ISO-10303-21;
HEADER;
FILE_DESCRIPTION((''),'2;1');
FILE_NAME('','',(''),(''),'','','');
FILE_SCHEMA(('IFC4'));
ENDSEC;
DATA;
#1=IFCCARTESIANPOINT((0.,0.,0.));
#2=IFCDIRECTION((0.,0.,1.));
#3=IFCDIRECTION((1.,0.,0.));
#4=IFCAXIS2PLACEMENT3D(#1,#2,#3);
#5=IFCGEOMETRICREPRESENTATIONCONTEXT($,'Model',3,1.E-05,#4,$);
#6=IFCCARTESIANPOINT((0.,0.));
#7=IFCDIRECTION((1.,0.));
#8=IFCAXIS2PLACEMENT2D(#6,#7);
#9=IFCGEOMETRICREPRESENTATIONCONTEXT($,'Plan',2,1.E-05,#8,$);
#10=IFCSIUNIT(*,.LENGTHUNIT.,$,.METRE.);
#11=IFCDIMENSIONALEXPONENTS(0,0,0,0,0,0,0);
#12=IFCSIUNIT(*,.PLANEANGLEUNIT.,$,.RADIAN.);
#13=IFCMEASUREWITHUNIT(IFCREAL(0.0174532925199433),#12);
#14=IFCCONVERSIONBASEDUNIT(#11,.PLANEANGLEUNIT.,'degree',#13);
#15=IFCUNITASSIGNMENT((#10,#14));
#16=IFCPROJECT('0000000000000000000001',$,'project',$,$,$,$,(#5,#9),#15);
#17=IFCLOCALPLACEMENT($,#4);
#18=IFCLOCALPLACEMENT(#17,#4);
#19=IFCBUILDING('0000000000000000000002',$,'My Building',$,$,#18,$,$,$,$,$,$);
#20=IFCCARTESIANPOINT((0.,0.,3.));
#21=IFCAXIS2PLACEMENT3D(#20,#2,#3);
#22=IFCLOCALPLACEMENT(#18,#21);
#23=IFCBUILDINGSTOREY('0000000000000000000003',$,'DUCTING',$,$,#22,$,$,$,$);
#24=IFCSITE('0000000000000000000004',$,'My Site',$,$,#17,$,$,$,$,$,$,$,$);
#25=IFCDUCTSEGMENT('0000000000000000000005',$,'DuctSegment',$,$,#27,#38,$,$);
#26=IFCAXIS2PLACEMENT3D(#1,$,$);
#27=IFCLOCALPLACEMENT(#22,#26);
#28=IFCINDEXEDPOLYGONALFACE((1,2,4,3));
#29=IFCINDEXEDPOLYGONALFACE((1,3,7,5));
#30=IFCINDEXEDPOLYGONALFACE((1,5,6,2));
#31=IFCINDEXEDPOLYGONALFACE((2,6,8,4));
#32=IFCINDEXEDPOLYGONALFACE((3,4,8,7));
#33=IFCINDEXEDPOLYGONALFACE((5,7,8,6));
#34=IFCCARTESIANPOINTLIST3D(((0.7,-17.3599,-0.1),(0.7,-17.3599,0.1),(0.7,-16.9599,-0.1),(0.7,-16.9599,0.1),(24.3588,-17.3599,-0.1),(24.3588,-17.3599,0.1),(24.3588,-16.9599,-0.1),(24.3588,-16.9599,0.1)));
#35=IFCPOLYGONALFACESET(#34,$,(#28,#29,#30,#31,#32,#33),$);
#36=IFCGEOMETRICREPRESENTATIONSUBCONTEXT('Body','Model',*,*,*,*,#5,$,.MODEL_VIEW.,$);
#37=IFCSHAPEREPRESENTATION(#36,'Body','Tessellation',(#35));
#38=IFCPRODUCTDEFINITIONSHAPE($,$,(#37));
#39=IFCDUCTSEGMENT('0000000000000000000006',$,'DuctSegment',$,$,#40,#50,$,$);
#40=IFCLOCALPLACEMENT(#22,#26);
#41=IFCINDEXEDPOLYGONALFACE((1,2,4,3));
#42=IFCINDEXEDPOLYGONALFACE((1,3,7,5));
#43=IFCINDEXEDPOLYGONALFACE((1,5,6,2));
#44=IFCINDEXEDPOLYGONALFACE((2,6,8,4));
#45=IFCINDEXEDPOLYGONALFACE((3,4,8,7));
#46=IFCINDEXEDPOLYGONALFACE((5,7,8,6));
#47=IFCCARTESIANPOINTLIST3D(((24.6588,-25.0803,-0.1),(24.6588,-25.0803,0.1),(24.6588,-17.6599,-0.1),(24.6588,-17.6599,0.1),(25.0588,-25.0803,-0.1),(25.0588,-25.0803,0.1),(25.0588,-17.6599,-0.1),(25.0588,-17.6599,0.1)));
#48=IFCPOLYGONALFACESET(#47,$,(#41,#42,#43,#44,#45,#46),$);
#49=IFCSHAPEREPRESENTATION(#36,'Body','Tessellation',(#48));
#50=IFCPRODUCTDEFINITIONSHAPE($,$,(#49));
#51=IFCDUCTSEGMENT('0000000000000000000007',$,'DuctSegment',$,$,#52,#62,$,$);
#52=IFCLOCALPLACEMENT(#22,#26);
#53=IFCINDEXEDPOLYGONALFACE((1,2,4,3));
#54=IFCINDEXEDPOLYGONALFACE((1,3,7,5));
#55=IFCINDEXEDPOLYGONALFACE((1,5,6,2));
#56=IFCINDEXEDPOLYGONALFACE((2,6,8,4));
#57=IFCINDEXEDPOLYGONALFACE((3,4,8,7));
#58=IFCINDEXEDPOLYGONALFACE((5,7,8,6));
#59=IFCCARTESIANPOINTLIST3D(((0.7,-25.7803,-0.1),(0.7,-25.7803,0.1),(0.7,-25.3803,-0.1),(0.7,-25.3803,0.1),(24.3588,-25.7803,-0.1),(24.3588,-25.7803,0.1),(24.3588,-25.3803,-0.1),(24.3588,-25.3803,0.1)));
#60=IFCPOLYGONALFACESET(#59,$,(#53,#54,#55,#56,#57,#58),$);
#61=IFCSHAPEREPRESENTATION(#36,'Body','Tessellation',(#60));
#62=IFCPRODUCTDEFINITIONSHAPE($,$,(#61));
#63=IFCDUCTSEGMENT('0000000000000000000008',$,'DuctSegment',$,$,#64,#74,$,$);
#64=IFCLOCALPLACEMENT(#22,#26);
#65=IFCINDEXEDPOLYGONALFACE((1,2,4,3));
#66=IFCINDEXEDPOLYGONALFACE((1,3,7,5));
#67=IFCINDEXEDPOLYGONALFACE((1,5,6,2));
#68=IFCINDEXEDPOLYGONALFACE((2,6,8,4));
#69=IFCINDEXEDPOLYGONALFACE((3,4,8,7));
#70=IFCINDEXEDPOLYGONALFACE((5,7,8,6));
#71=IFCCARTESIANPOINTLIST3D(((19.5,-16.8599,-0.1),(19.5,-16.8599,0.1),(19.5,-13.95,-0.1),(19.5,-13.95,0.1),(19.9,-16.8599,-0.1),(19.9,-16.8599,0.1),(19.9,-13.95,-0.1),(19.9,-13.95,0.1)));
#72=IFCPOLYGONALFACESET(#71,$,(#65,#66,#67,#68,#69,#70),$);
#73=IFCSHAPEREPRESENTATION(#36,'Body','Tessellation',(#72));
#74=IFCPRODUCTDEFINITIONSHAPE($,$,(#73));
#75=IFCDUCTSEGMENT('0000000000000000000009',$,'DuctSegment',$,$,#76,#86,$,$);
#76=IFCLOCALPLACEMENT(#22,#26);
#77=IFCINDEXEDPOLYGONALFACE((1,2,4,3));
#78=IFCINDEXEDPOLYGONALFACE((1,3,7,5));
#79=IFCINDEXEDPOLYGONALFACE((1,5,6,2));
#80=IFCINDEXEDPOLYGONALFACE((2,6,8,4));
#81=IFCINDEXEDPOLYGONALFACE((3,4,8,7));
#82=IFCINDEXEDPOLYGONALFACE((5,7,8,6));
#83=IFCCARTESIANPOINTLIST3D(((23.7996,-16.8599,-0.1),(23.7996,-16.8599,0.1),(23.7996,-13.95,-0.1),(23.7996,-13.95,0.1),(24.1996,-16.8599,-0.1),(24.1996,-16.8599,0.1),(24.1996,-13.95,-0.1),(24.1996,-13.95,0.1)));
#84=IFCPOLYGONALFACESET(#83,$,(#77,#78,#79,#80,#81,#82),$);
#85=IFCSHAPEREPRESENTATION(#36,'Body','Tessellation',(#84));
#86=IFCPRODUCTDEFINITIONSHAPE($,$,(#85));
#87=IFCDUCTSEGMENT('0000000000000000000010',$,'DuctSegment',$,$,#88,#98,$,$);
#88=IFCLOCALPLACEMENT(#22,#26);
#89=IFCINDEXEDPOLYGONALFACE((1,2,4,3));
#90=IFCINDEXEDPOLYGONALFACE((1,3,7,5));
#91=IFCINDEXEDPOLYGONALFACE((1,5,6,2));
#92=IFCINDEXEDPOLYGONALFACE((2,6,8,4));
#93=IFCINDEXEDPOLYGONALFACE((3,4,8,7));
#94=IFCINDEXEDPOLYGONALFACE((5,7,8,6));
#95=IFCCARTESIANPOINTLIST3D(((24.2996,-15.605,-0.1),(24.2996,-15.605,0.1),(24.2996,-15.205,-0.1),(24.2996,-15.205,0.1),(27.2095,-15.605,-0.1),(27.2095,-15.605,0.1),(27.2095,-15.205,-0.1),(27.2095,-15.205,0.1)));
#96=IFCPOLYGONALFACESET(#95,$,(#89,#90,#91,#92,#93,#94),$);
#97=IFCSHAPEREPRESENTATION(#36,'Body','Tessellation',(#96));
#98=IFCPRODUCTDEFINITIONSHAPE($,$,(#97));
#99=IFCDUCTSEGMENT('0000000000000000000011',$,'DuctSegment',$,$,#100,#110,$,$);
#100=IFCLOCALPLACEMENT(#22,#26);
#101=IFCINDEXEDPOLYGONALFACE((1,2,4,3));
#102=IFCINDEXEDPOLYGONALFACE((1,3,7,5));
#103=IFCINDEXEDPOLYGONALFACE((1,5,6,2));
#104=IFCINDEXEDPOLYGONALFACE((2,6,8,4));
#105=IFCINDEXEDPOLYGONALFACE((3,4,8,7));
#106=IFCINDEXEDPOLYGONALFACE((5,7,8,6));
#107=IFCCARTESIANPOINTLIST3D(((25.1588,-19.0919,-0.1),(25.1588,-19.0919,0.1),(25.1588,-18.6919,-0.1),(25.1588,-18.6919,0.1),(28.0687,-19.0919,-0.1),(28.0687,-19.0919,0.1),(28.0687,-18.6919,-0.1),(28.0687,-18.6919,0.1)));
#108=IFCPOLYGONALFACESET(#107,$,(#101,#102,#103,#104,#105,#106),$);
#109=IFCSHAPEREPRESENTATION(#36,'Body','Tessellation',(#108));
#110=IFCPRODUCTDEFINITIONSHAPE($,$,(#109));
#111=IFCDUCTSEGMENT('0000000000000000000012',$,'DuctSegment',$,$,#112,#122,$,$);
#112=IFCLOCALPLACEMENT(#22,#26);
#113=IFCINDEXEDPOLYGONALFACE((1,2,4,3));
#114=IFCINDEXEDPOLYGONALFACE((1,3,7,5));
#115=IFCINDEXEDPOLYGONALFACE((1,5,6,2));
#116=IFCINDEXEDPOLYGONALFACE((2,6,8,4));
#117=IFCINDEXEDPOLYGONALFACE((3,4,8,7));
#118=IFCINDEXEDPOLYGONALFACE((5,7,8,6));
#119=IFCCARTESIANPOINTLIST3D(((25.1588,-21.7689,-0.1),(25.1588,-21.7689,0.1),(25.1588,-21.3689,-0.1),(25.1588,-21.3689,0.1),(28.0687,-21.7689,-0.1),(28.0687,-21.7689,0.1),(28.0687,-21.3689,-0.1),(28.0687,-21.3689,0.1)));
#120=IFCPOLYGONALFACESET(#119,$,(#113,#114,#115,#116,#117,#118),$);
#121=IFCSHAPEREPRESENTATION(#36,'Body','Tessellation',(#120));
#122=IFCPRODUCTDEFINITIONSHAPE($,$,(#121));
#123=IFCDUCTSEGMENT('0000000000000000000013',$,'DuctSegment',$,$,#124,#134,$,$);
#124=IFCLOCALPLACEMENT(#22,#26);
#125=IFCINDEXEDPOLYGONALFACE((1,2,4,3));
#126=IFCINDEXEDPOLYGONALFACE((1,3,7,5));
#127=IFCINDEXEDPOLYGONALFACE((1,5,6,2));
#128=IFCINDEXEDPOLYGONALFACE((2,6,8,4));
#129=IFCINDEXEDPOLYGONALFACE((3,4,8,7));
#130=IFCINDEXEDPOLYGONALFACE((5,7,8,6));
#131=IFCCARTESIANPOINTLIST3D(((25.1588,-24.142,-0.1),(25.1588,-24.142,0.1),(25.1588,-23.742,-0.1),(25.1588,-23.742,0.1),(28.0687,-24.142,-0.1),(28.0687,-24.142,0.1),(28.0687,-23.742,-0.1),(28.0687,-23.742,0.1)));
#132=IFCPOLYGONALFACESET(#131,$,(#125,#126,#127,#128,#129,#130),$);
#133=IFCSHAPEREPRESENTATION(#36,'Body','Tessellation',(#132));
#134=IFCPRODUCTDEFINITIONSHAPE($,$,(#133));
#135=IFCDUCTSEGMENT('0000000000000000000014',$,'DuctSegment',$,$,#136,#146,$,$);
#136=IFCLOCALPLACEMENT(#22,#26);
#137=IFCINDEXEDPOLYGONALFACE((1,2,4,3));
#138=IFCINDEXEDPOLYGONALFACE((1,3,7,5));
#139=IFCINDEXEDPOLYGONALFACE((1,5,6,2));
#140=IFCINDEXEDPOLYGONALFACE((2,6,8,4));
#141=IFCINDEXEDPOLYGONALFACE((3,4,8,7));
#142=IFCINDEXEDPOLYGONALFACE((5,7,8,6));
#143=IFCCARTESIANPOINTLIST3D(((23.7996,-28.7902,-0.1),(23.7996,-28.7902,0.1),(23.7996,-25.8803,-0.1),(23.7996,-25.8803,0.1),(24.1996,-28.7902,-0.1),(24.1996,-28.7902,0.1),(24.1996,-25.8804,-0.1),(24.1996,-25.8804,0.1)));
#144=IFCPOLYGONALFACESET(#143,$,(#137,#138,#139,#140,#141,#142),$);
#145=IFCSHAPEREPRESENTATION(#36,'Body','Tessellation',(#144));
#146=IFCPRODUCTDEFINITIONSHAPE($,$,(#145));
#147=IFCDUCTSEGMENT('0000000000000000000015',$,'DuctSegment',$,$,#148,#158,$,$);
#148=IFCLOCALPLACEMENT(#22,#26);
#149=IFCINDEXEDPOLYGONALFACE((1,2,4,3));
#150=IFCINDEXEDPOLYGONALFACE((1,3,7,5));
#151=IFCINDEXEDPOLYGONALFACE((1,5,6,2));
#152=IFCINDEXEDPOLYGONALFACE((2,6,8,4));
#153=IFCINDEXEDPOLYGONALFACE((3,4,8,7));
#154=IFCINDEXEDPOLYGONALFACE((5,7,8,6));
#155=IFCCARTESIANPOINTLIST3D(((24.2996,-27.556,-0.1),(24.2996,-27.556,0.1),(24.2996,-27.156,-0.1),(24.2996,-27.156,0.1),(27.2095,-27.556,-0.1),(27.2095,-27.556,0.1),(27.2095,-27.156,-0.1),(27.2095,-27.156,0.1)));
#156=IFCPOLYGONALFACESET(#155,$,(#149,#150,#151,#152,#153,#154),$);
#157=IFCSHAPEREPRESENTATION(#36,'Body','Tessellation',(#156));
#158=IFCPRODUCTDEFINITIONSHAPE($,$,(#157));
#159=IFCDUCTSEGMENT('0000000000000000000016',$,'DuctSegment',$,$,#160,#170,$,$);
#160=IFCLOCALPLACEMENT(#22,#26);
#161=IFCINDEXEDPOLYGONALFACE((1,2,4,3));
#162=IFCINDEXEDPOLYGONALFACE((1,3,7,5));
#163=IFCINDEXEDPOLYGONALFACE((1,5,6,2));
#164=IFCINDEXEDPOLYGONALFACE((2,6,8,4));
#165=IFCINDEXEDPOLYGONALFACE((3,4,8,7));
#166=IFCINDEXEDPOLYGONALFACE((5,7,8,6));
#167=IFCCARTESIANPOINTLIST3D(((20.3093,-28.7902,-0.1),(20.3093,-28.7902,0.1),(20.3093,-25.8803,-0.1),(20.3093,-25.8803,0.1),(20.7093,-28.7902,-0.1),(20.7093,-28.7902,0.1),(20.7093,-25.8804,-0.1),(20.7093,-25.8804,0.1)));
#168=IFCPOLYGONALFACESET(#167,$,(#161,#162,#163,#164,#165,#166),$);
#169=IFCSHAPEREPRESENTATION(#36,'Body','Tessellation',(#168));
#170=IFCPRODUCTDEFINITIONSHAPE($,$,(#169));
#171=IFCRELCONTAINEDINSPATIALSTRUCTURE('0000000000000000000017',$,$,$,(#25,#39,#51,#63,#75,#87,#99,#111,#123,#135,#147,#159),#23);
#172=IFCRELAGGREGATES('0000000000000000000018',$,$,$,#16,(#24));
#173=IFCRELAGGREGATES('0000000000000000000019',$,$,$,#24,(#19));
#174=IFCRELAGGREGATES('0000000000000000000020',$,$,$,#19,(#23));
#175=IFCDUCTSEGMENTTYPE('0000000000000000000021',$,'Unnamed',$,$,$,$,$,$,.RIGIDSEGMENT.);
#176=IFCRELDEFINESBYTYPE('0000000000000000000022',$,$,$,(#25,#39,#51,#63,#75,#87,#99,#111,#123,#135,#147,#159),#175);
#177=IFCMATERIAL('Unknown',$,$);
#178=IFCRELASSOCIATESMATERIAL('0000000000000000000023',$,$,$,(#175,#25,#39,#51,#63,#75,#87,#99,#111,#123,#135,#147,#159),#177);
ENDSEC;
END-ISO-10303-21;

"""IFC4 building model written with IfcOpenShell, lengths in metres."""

from ifc_helpers import new_model, entity, si_unit, converted_unit, frame, origin_with_axes, origin_2d_with_axis, place, context, subcontext, project, spatial, rectangle, extrude, material, material_profile, profile_set, profile_usage, type_object, element, save


model = new_model("IFC4")

# Units and contexts
model_context = context("Model", 3, precision=1e-05, world=origin_with_axes())
plan_context = context("Plan", 2, precision=1e-05, world=origin_2d_with_axis())
body_context = subcontext(model_context, "Body", "Model", "MODEL_VIEW")
ifc_project = project(units=[si_unit("LENGTHUNIT", "METRE"), converted_unit("PLANEANGLEUNIT", "degree", entity("IfcReal", 0.0174532925199433), si_unit("PLANEANGLEUNIT", "RADIAN"), dimensions=[0, 0, 0, 0, 0, 0, 0])], contexts=[model_context, plan_context])

# Site, building, storey
site_placement = place(None, origin_with_axes())
site = spatial("IfcSite", under=ifc_project, at=site_placement, Name="My Site")
building_placement = place(site_placement, origin_with_axes())
building = spatial("IfcBuilding", under=site, at=building_placement, Name="My Building")
storey_placement = place(building_placement, frame((0.0, 0.0, 3.0), z_axis=(0.0, 0.0, 1.0), x_axis=(1.0, 0.0, 0.0)))
storey = spatial("IfcBuildingStorey", under=building, at=storey_placement, Name="DUCTING")

# Duct segments
ifc_material = material(Name="Unknown")
ifc_material_profile_1 = material_profile(ifc_material, rectangle(XDim=0.4, YDim=0.2))
ifc_profile_set_1 = profile_set([ifc_material_profile_1])
ifc_profile_usage_1 = profile_usage(ifc_profile_set_1, cardinal=5)
duct_segment_type = type_object("IfcDuctSegmentType", Name="Unnamed", PredefinedType="RIGIDSEGMENT", material=ifc_profile_set_1)
duct_segment_1_placement = place(storey_placement, frame((24.3588, -17.1599, 0.0), z_axis=(-1.0, 0.0, 0.0), x_axis=(0.0, -1.0, 0.0)))
element("IfcDuctSegment", 1, at=duct_segment_1_placement, inside=storey, type_object=duct_segment_type, material=ifc_profile_usage_1, Name="DuctSegment", context=body_context, shape_type="SweptSolid", body=[
    extrude(rectangle(XDim=0.4, YDim=0.2), origin_with_axes(), (0.0, 0.0, 1.0), 23.6588),
])
ifc_profile_usage_2 = profile_usage(ifc_profile_set_1, cardinal=5)
duct_segment_2_placement = place(storey_placement, frame((24.8588, -17.6599, 0.0), z_axis=(0.0, -1.0, 0.0), x_axis=(1.0, 0.0, 0.0)))
element("IfcDuctSegment", 2, at=duct_segment_2_placement, inside=storey, type_object=duct_segment_type, material=ifc_profile_usage_2, Name="DuctSegment", context=body_context, shape_type="SweptSolid", body=[
    extrude(rectangle(XDim=0.4, YDim=0.2), origin_with_axes(), (0.0, 0.0, 1.0), 7.4205),
])
ifc_profile_usage_3 = profile_usage(ifc_profile_set_1, cardinal=5)
duct_segment_3_placement = place(storey_placement, frame((24.3588, -25.5803, 0.0), z_axis=(-1.0, 0.0, 0.0), x_axis=(0.0, -1.0, 0.0)))
element("IfcDuctSegment", 3, at=duct_segment_3_placement, inside=storey, type_object=duct_segment_type, material=ifc_profile_usage_3, Name="DuctSegment", context=body_context, shape_type="SweptSolid", body=[
    extrude(rectangle(XDim=0.4, YDim=0.2), origin_with_axes(), (0.0, 0.0, 1.0), 23.6588),
])
ifc_profile_usage_4 = profile_usage(ifc_profile_set_1, cardinal=5)
duct_segment_4_placement = place(storey_placement, frame((19.7, -13.95, 0.0), z_axis=(0.0, -1.0, 0.0), x_axis=(1.0, 0.0, 0.0)))
element("IfcDuctSegment", 4, at=duct_segment_4_placement, inside=storey, type_object=duct_segment_type, material=ifc_profile_usage_4, Name="DuctSegment", context=body_context, shape_type="SweptSolid", body=[
    extrude(rectangle(XDim=0.4, YDim=0.2), origin_with_axes(), (0.0, 0.0, 1.0), 2.9099),
])
ifc_profile_usage_5 = profile_usage(ifc_profile_set_1, cardinal=5)
duct_segment_5_placement = place(storey_placement, frame((23.9996, -13.95, 0.0), z_axis=(0.0, -1.0, 0.0), x_axis=(1.0, 0.0, 0.0)))
element("IfcDuctSegment", 5, at=duct_segment_5_placement, inside=storey, type_object=duct_segment_type, material=ifc_profile_usage_5, Name="DuctSegment", context=body_context, shape_type="SweptSolid", body=[
    extrude(rectangle(XDim=0.4, YDim=0.2), origin_with_axes(), (0.0, 0.0, 1.0), 2.9099),
])
ifc_profile_usage_6 = profile_usage(ifc_profile_set_1, cardinal=5)
duct_segment_6_placement = place(storey_placement, frame((27.2095, -15.405, 0.0), z_axis=(-1.0, 0.0, 0.0), x_axis=(0.0, -1.0, 0.0)))
element("IfcDuctSegment", 6, at=duct_segment_6_placement, inside=storey, type_object=duct_segment_type, material=ifc_profile_usage_6, Name="DuctSegment", context=body_context, shape_type="SweptSolid", body=[
    extrude(rectangle(XDim=0.4, YDim=0.2), origin_with_axes(), (0.0, 0.0, 1.0), 2.9099),
])
ifc_profile_usage_7 = profile_usage(ifc_profile_set_1, cardinal=5)
duct_segment_7_placement = place(storey_placement, frame((28.0687, -18.8919, 0.0), z_axis=(-1.0, 0.0, 0.0), x_axis=(0.0, -1.0, 0.0)))
element("IfcDuctSegment", 7, at=duct_segment_7_placement, inside=storey, type_object=duct_segment_type, material=ifc_profile_usage_7, Name="DuctSegment", context=body_context, shape_type="SweptSolid", body=[
    extrude(rectangle(XDim=0.4, YDim=0.2), origin_with_axes(), (0.0, 0.0, 1.0), 2.9099),
])
ifc_profile_usage_8 = profile_usage(ifc_profile_set_1, cardinal=5)
duct_segment_8_placement = place(storey_placement, frame((28.0687, -21.5689, 0.0), z_axis=(-1.0, 0.0, 0.0), x_axis=(0.0, -1.0, 0.0)))
element("IfcDuctSegment", 8, at=duct_segment_8_placement, inside=storey, type_object=duct_segment_type, material=ifc_profile_usage_8, Name="DuctSegment", context=body_context, shape_type="SweptSolid", body=[
    extrude(rectangle(XDim=0.4, YDim=0.2), origin_with_axes(), (0.0, 0.0, 1.0), 2.9099),
])
ifc_profile_usage_9 = profile_usage(ifc_profile_set_1, cardinal=5)
duct_segment_9_placement = place(storey_placement, frame((28.0687, -23.942, 0.0), z_axis=(-1.0, 0.0, 0.0), x_axis=(0.0, -1.0, 0.0)))
element("IfcDuctSegment", 9, at=duct_segment_9_placement, inside=storey, type_object=duct_segment_type, material=ifc_profile_usage_9, Name="DuctSegment", context=body_context, shape_type="SweptSolid", body=[
    extrude(rectangle(XDim=0.4, YDim=0.2), origin_with_axes(), (0.0, 0.0, 1.0), 2.9099),
])
ifc_profile_usage_10 = profile_usage(ifc_profile_set_1, cardinal=5)
duct_segment_10_placement = place(storey_placement, frame((23.9996, -28.7902, 0.0), z_axis=(0.000001, 1.0, 0.0), x_axis=(-1.0, 0.000001, 0.0)))
element("IfcDuctSegment", 10, at=duct_segment_10_placement, inside=storey, type_object=duct_segment_type, material=ifc_profile_usage_10, Name="DuctSegment", context=body_context, shape_type="SweptSolid", body=[
    extrude(rectangle(XDim=0.4, YDim=0.2), origin_with_axes(), (0.0, 0.0, 1.0), 2.9099),
])
ifc_profile_usage_11 = profile_usage(ifc_profile_set_1, cardinal=5)
duct_segment_11_placement = place(storey_placement, frame((27.2095, -27.356, 0.0), z_axis=(-1.0, 0.000001, 0.0), x_axis=(-0.000001, -1.0, 0.0)))
element("IfcDuctSegment", 11, at=duct_segment_11_placement, inside=storey, type_object=duct_segment_type, material=ifc_profile_usage_11, Name="DuctSegment", context=body_context, shape_type="SweptSolid", body=[
    extrude(rectangle(XDim=0.4, YDim=0.2), origin_with_axes(), (0.0, 0.0, 1.0), 2.9099),
])
ifc_profile_usage_12 = profile_usage(ifc_profile_set_1, cardinal=5)
duct_segment_12_placement = place(storey_placement, frame((20.5093, -28.7902, 0.0), z_axis=(0.000001, 1.0, 0.0), x_axis=(-1.0, 0.000001, 0.0)))
element("IfcDuctSegment", 12, at=duct_segment_12_placement, inside=storey, type_object=duct_segment_type, material=ifc_profile_usage_12, Name="DuctSegment", context=body_context, shape_type="SweptSolid", body=[
    extrude(rectangle(XDim=0.4, YDim=0.2), origin_with_axes(), (0.0, 0.0, 1.0), 2.9099),
])

save(model, "model.ifc")
